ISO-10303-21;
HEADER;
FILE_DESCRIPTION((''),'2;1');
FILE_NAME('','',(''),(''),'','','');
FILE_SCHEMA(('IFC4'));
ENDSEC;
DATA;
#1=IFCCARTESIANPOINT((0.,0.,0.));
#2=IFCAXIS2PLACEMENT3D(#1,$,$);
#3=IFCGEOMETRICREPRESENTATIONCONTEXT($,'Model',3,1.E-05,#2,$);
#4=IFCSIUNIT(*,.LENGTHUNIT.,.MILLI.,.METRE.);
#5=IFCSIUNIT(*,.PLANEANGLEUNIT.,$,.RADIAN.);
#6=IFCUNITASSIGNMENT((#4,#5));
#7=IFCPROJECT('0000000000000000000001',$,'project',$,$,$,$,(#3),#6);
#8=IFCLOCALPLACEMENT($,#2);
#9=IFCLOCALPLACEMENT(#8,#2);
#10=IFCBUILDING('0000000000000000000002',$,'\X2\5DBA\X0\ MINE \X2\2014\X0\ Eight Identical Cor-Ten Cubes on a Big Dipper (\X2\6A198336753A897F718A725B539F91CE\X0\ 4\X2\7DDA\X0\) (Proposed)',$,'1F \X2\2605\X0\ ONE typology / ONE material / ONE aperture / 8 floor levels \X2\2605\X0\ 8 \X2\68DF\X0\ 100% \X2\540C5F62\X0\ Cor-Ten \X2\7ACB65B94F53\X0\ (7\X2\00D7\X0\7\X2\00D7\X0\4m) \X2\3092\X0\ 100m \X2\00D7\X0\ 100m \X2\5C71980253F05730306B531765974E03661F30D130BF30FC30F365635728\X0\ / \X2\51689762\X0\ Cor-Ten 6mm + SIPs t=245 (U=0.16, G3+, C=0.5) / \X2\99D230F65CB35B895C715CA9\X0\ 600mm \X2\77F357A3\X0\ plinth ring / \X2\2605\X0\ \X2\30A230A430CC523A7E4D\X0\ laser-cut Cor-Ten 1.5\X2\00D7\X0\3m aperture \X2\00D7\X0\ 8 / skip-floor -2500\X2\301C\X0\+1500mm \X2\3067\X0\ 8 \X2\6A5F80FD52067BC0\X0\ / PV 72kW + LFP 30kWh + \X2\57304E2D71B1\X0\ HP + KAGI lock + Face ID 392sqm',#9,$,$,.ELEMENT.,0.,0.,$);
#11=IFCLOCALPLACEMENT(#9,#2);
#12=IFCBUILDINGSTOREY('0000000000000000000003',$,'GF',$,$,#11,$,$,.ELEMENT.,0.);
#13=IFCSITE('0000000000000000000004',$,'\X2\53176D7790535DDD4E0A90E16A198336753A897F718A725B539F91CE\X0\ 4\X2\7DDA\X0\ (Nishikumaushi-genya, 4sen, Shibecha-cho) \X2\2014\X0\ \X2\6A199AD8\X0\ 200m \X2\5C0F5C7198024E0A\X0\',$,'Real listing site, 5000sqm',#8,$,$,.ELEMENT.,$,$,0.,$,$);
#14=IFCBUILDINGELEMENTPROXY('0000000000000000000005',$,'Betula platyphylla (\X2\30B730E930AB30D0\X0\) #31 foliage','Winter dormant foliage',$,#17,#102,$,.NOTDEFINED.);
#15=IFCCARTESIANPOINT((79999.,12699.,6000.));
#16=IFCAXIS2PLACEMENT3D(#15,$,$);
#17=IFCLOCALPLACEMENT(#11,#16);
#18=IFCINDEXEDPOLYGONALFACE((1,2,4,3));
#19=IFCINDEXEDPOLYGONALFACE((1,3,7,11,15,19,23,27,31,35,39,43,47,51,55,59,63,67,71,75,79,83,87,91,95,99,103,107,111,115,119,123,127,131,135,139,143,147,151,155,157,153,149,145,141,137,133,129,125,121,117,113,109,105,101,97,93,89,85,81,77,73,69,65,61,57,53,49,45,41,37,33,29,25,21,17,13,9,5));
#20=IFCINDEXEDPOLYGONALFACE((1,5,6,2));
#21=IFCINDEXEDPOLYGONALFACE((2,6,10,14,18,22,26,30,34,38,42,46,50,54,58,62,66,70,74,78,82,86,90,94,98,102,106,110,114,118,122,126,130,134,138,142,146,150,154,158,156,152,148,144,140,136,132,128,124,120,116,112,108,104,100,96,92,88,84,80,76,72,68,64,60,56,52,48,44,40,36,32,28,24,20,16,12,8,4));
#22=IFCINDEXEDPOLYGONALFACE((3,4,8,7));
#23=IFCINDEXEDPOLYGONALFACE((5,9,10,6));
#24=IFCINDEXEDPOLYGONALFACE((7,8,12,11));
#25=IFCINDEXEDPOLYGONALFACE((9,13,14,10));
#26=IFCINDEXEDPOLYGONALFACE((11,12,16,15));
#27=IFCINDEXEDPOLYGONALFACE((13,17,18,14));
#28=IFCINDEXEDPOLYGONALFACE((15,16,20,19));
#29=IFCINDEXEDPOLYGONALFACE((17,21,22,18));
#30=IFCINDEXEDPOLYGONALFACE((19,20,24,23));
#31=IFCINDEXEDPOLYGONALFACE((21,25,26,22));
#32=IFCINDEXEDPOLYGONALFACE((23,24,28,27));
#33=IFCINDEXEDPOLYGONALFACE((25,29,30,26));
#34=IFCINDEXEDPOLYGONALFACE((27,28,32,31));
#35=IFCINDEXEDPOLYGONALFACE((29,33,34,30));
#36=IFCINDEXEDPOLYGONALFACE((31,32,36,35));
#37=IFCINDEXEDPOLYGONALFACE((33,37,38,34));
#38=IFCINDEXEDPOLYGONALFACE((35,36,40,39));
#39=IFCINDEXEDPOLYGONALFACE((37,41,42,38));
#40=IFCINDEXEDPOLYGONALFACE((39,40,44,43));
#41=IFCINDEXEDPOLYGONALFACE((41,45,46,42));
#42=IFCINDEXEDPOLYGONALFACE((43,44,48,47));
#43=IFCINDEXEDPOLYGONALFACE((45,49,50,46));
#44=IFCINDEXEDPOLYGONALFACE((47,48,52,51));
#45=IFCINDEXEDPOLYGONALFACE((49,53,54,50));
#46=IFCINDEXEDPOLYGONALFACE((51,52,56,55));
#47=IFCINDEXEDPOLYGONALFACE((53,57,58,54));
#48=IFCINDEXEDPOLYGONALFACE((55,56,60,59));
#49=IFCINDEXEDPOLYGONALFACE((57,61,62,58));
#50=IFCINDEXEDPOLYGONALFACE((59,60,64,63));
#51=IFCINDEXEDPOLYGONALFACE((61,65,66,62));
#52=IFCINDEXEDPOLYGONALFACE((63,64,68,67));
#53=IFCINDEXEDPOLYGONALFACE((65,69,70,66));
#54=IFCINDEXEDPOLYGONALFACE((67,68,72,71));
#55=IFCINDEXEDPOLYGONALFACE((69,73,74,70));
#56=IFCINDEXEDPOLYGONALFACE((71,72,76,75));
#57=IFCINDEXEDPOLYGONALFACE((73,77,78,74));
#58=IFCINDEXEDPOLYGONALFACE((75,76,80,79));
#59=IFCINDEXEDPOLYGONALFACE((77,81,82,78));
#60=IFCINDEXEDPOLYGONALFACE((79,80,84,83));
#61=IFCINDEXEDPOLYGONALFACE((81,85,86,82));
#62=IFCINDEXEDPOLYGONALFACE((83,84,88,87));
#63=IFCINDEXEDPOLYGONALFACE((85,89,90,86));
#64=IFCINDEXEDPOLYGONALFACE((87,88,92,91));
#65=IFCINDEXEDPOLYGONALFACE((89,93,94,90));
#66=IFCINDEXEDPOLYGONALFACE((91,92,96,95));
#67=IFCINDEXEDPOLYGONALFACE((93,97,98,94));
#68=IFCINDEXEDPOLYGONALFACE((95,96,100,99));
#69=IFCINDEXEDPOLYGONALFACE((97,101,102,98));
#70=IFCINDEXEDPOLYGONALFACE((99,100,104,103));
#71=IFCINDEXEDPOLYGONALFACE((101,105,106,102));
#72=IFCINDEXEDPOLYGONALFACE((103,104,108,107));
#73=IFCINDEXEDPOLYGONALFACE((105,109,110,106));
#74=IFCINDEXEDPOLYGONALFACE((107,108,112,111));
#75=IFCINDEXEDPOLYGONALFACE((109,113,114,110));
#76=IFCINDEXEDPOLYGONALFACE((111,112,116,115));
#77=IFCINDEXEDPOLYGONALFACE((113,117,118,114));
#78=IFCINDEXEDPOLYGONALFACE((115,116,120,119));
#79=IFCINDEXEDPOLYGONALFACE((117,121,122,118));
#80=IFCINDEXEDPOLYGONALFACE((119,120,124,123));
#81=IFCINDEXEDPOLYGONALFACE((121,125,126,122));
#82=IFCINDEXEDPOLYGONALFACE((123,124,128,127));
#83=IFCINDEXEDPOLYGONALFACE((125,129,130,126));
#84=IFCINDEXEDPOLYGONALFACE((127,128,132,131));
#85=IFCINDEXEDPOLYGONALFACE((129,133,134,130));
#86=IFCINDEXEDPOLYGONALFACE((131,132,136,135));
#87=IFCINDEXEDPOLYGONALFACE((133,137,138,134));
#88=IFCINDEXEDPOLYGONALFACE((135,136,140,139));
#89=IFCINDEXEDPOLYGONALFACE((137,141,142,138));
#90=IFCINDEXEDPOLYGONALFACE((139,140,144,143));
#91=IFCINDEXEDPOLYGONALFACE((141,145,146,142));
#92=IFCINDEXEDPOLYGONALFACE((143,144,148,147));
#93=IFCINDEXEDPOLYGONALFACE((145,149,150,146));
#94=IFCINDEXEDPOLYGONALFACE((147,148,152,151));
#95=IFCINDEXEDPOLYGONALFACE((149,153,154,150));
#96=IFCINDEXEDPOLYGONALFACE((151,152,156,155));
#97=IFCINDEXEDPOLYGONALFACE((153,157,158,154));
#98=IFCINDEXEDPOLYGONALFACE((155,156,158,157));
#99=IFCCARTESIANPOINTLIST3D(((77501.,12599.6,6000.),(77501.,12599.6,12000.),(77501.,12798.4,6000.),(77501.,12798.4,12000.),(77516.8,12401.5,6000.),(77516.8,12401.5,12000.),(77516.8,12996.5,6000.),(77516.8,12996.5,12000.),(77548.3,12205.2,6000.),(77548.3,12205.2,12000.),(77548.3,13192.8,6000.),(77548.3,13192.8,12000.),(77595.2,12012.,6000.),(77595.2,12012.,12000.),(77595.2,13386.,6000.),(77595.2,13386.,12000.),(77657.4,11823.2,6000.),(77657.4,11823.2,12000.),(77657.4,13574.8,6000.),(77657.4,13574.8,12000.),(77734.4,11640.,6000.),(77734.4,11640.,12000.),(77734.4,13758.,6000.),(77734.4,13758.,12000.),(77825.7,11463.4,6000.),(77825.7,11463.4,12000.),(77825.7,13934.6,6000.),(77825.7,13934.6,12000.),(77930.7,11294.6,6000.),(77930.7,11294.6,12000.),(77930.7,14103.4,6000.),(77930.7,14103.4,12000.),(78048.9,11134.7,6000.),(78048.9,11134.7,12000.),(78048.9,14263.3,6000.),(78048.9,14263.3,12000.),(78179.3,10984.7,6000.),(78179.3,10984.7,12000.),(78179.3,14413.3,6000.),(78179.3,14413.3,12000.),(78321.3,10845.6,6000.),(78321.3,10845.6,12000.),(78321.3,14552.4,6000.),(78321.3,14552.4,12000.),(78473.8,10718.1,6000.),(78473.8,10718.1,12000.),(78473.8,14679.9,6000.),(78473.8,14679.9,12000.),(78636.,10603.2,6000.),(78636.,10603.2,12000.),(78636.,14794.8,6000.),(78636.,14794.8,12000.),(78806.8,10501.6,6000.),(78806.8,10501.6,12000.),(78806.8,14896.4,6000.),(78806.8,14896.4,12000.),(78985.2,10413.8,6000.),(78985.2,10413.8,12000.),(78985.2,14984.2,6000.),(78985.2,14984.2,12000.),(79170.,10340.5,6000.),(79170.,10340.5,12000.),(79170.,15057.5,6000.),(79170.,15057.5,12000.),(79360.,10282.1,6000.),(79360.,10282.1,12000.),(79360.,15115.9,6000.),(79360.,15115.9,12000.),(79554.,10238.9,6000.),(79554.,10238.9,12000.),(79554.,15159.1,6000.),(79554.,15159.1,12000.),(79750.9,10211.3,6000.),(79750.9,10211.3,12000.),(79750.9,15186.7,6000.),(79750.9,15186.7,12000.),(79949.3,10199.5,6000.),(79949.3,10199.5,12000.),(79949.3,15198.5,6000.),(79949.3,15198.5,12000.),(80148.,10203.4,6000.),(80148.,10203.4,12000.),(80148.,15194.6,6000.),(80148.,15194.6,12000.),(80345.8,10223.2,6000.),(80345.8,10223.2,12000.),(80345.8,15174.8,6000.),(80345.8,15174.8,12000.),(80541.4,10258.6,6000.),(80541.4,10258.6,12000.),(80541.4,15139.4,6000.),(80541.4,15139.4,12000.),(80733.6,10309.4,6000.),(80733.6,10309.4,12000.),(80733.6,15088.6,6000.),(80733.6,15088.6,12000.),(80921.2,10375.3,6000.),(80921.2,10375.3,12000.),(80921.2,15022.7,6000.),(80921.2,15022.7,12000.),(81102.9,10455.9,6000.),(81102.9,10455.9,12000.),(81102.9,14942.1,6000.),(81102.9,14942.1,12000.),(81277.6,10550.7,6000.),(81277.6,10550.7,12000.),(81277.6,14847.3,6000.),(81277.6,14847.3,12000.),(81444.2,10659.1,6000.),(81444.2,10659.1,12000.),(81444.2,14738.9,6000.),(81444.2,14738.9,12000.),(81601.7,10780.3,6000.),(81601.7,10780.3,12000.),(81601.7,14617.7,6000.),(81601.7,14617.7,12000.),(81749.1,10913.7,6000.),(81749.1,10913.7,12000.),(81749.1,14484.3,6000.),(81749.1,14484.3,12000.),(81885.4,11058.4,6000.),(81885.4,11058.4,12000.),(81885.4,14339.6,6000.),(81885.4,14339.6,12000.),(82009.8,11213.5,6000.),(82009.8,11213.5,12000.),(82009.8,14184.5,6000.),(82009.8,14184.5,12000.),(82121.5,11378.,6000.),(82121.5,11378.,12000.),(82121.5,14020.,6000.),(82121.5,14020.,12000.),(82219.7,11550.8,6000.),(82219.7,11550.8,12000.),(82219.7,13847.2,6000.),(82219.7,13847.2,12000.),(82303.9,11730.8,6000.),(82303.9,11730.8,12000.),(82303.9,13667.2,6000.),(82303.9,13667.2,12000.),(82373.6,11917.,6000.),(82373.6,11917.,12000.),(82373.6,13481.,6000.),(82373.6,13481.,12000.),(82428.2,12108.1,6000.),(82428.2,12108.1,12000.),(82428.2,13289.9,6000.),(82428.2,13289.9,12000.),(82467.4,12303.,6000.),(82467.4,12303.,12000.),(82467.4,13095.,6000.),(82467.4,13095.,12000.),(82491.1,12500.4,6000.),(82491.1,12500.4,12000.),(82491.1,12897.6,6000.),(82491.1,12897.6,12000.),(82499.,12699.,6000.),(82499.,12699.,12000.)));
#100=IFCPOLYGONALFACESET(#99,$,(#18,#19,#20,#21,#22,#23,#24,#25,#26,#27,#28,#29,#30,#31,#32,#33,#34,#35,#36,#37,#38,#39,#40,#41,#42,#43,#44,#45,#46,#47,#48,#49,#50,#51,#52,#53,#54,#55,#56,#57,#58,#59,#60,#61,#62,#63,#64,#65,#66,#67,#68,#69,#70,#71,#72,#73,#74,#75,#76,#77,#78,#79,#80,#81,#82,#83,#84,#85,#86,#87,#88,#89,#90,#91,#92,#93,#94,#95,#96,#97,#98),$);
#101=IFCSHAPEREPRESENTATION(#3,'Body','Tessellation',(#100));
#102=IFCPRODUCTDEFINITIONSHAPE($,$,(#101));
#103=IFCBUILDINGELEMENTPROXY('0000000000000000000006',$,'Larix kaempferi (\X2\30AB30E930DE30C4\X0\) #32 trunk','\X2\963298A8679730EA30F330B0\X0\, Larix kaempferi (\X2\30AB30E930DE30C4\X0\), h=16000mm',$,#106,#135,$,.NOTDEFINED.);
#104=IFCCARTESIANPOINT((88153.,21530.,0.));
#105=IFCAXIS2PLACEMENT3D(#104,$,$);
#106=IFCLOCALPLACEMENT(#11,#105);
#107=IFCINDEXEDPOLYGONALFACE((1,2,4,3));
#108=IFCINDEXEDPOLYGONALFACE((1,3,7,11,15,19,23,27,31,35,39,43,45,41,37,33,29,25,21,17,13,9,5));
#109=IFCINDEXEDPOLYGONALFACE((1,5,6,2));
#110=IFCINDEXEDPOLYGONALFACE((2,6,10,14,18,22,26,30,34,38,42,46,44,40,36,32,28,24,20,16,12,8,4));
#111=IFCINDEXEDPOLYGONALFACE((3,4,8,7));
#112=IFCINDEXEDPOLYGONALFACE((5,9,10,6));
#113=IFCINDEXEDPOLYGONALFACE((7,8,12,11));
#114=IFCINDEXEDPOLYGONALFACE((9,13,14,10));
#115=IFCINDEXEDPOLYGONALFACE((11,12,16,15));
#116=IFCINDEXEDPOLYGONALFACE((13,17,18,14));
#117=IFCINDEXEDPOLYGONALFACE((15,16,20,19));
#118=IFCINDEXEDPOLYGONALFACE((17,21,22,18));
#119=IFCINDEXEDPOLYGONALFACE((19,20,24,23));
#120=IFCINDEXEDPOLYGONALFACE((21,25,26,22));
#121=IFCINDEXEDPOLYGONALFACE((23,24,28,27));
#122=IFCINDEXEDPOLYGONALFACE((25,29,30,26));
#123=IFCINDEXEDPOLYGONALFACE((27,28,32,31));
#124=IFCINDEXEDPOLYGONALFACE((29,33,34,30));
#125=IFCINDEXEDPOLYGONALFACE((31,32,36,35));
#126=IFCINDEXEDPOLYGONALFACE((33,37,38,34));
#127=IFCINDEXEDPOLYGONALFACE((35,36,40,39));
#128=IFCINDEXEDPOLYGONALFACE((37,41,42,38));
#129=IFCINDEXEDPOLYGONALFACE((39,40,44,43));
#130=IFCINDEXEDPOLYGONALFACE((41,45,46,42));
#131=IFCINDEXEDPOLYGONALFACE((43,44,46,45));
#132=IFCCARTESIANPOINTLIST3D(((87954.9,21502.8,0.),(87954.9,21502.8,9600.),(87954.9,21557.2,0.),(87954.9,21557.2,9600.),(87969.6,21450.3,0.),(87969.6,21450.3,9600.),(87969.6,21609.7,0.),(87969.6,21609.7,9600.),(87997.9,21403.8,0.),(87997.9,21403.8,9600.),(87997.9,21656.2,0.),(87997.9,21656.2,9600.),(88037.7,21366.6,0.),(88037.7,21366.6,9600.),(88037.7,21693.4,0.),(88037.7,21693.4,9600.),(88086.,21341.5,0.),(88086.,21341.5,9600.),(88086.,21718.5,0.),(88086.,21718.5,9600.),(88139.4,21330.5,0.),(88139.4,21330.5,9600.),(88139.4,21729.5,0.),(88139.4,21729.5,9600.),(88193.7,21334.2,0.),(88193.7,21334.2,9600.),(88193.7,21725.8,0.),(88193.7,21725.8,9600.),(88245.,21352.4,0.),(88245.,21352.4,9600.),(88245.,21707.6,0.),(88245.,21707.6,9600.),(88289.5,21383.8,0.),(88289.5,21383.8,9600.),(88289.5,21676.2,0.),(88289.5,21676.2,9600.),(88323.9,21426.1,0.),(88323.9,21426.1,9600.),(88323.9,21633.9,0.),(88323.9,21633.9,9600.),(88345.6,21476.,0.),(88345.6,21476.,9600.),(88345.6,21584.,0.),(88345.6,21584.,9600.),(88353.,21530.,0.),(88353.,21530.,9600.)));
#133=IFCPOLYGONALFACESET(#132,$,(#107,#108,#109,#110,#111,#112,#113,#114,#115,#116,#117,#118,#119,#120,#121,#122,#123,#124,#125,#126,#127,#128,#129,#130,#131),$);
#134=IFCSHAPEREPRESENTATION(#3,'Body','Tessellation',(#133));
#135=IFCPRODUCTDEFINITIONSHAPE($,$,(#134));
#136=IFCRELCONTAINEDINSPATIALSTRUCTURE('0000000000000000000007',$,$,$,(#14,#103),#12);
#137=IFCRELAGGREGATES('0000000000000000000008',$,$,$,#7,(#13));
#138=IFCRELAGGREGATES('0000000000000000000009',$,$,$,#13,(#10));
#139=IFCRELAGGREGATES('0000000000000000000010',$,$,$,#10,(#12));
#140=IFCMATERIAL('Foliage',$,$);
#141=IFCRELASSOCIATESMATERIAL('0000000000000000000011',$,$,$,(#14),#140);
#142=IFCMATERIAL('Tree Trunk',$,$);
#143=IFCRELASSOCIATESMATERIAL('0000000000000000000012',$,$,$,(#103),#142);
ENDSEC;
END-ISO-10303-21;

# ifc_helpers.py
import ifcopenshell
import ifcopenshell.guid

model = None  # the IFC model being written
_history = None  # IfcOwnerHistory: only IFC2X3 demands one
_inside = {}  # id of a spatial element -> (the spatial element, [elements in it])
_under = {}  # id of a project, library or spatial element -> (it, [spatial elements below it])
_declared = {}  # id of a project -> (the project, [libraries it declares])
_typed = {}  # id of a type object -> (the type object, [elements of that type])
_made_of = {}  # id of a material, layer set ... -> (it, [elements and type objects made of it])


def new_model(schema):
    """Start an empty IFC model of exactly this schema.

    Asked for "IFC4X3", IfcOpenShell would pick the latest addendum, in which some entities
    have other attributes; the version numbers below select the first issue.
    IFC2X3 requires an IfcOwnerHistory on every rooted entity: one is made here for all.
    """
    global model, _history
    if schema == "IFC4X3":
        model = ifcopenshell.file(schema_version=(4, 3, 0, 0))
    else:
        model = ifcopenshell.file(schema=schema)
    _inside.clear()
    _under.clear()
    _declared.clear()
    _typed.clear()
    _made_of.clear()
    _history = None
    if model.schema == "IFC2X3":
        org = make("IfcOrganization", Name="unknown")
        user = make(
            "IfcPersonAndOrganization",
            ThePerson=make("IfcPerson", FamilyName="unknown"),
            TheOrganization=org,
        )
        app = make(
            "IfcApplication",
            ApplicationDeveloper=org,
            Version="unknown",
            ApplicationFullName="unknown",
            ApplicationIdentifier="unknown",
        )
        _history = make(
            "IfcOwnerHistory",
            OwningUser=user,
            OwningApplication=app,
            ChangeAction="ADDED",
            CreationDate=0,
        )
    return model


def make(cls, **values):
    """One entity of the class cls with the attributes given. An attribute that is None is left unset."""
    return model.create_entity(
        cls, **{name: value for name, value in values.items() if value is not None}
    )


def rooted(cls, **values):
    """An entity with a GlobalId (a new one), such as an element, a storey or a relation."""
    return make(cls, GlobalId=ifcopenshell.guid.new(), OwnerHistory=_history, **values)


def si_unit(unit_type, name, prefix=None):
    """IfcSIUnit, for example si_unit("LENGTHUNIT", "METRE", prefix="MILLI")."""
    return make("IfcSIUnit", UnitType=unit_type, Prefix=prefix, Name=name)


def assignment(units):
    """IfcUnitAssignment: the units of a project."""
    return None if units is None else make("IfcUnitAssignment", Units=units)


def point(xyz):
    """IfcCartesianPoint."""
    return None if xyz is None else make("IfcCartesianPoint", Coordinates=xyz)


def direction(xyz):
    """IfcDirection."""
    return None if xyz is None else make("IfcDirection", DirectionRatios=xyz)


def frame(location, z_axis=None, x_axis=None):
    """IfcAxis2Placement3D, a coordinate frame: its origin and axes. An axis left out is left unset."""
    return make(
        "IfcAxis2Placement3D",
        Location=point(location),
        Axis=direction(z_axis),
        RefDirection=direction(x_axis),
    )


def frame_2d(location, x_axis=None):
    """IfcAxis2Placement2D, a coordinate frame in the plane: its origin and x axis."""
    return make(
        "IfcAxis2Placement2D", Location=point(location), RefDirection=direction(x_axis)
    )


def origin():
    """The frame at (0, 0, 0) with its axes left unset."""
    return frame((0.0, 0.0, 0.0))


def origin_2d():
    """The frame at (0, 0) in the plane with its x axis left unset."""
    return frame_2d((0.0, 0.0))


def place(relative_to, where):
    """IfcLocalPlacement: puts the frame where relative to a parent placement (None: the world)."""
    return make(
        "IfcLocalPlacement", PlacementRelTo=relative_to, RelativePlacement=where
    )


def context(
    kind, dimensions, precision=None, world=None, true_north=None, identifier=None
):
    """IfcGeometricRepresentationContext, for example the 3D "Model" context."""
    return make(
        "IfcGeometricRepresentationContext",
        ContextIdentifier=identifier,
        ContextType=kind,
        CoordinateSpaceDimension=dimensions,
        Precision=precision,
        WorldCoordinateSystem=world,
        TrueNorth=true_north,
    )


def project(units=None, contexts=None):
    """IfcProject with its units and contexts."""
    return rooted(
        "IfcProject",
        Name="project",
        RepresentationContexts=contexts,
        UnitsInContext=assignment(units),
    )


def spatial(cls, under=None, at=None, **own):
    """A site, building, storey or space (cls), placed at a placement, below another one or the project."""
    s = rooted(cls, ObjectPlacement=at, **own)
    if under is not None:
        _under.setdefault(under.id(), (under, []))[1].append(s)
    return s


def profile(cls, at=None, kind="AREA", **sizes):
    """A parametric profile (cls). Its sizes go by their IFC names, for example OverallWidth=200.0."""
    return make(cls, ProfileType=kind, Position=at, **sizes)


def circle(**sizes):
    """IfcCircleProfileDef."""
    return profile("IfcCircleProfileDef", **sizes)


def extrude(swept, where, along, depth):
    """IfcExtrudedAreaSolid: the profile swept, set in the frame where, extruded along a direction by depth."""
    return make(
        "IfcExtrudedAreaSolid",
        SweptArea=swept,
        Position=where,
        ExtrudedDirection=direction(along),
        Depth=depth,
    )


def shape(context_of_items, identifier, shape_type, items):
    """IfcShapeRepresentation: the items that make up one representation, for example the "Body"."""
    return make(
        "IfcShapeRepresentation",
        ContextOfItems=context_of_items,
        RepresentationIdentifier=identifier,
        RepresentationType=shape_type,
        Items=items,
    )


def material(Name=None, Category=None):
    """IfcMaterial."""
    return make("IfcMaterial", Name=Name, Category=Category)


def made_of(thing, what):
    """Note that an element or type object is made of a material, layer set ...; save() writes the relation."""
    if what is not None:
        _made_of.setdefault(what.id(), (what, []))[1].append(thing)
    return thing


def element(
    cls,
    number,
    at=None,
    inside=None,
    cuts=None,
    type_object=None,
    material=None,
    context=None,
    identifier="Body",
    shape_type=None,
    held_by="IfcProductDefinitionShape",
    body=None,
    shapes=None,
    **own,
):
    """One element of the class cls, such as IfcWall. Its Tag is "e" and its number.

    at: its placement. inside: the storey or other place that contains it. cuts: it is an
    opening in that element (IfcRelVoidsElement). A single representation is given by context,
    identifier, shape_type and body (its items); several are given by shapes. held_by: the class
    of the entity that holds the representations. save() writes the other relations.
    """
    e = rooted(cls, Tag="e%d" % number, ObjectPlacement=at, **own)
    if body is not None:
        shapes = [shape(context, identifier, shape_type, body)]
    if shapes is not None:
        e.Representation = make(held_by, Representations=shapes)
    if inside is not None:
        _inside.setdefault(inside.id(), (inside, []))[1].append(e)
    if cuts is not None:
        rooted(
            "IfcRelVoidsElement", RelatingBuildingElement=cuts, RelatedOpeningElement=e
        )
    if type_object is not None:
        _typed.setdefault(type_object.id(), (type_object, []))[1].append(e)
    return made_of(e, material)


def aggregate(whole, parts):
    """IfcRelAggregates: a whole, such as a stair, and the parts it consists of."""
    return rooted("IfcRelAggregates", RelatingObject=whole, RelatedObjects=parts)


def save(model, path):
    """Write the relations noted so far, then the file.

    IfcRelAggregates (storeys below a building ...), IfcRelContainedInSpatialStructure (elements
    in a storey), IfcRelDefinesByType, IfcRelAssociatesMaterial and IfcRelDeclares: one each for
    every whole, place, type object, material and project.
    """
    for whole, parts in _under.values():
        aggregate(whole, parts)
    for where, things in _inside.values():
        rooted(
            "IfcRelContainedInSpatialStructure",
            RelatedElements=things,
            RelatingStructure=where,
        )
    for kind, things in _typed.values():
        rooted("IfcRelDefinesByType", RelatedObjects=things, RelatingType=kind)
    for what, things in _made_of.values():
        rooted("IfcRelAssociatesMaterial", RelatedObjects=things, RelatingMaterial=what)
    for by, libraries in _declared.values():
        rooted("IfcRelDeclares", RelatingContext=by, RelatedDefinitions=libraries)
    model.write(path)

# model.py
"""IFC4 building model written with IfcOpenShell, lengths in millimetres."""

from ifc_helpers import new_model, si_unit, frame, origin, origin_2d, place, context, project, spatial, circle, extrude, material, element, save


model = new_model("IFC4")

# Units and contexts
model_context = context("Model", 3, precision=1e-05, world=origin())
ifc_project = project(units=[si_unit("LENGTHUNIT", "METRE", prefix="MILLI"), si_unit("PLANEANGLEUNIT", "RADIAN")], contexts=[model_context])

# Site, building, storey
site_placement = place(None, origin())
site = spatial("IfcSite", under=ifc_project, at=site_placement, Name="北海道川上郡標茶町西熊牛原野 4線 (Nishikumaushi-genya, 4sen, Shibecha-cho) — 標高 200m 小山頂上", ObjectType="Real listing site, 5000sqm", CompositionType="ELEMENT", RefElevation=0.0)
building_placement = place(site_placement, origin())
building = spatial("IfcBuilding", under=site, at=building_placement, Name="嶺 MINE — Eight Identical Cor-Ten Cubes on a Big Dipper (標茶町西熊牛原野 4線) (Proposed)", ObjectType="1F ★ ONE typology / ONE material / ONE aperture / 8 floor levels ★ 8 棟 100% 同形 Cor-Ten 立方体 (7×7×4m) を 100m × 100m 山頂台地に北斗七星パターン散在 / 全面 Cor-Ten 6mm + SIPs t=245 (U=0.16, G3+, C=0.5) / 駒ヶ岳安山岩 600mm 石垣 plinth ring / ★ アイヌ刺繍 laser-cut Cor-Ten 1.5×3m aperture × 8 / skip-floor -2500〜+1500mm で 8 機能分節 / PV 72kW + LFP 30kWh + 地中熱 HP + KAGI lock + Face ID 392sqm", CompositionType="ELEMENT", ElevationOfRefHeight=0.0, ElevationOfTerrain=0.0)
storey_placement = place(building_placement, origin())
storey = spatial("IfcBuildingStorey", under=building, at=storey_placement, Name="GF", CompositionType="ELEMENT", Elevation=0.0)

# Building element proxies
ifc_material_1 = material(Name="Tree Trunk")
ifc_material_2 = material(Name="Foliage")
proxy_1_placement = place(storey_placement, frame((79999.0, 12699.0, 6000.0)))
element("IfcBuildingElementProxy", 1, at=proxy_1_placement, inside=storey, material=ifc_material_2, Name="Betula platyphylla (シラカバ) #31 foliage", Description="Winter dormant foliage", PredefinedType="NOTDEFINED", context=model_context, shape_type="SweptSolid", body=[
    extrude(circle(Radius=2500.0, at=origin_2d()), frame((79999.0, 12699.0, 6000.0)), (0.0, 0.0, 1.0), 6000.0),
])
proxy_2_placement = place(storey_placement, frame((88153.0, 21530.0, 0.0)))
element("IfcBuildingElementProxy", 2, at=proxy_2_placement, inside=storey, material=ifc_material_1, Name="Larix kaempferi (カラマツ) #32 trunk", Description="防風林リング, Larix kaempferi (カラマツ), h=16000mm", PredefinedType="NOTDEFINED", context=model_context, shape_type="SweptSolid", body=[
    extrude(circle(Radius=200.0, at=origin_2d()), frame((88153.0, 21530.0, 0.0)), (0.0, 0.0, 1.0), 9600.0),
])

save(model, "model.ifc")
